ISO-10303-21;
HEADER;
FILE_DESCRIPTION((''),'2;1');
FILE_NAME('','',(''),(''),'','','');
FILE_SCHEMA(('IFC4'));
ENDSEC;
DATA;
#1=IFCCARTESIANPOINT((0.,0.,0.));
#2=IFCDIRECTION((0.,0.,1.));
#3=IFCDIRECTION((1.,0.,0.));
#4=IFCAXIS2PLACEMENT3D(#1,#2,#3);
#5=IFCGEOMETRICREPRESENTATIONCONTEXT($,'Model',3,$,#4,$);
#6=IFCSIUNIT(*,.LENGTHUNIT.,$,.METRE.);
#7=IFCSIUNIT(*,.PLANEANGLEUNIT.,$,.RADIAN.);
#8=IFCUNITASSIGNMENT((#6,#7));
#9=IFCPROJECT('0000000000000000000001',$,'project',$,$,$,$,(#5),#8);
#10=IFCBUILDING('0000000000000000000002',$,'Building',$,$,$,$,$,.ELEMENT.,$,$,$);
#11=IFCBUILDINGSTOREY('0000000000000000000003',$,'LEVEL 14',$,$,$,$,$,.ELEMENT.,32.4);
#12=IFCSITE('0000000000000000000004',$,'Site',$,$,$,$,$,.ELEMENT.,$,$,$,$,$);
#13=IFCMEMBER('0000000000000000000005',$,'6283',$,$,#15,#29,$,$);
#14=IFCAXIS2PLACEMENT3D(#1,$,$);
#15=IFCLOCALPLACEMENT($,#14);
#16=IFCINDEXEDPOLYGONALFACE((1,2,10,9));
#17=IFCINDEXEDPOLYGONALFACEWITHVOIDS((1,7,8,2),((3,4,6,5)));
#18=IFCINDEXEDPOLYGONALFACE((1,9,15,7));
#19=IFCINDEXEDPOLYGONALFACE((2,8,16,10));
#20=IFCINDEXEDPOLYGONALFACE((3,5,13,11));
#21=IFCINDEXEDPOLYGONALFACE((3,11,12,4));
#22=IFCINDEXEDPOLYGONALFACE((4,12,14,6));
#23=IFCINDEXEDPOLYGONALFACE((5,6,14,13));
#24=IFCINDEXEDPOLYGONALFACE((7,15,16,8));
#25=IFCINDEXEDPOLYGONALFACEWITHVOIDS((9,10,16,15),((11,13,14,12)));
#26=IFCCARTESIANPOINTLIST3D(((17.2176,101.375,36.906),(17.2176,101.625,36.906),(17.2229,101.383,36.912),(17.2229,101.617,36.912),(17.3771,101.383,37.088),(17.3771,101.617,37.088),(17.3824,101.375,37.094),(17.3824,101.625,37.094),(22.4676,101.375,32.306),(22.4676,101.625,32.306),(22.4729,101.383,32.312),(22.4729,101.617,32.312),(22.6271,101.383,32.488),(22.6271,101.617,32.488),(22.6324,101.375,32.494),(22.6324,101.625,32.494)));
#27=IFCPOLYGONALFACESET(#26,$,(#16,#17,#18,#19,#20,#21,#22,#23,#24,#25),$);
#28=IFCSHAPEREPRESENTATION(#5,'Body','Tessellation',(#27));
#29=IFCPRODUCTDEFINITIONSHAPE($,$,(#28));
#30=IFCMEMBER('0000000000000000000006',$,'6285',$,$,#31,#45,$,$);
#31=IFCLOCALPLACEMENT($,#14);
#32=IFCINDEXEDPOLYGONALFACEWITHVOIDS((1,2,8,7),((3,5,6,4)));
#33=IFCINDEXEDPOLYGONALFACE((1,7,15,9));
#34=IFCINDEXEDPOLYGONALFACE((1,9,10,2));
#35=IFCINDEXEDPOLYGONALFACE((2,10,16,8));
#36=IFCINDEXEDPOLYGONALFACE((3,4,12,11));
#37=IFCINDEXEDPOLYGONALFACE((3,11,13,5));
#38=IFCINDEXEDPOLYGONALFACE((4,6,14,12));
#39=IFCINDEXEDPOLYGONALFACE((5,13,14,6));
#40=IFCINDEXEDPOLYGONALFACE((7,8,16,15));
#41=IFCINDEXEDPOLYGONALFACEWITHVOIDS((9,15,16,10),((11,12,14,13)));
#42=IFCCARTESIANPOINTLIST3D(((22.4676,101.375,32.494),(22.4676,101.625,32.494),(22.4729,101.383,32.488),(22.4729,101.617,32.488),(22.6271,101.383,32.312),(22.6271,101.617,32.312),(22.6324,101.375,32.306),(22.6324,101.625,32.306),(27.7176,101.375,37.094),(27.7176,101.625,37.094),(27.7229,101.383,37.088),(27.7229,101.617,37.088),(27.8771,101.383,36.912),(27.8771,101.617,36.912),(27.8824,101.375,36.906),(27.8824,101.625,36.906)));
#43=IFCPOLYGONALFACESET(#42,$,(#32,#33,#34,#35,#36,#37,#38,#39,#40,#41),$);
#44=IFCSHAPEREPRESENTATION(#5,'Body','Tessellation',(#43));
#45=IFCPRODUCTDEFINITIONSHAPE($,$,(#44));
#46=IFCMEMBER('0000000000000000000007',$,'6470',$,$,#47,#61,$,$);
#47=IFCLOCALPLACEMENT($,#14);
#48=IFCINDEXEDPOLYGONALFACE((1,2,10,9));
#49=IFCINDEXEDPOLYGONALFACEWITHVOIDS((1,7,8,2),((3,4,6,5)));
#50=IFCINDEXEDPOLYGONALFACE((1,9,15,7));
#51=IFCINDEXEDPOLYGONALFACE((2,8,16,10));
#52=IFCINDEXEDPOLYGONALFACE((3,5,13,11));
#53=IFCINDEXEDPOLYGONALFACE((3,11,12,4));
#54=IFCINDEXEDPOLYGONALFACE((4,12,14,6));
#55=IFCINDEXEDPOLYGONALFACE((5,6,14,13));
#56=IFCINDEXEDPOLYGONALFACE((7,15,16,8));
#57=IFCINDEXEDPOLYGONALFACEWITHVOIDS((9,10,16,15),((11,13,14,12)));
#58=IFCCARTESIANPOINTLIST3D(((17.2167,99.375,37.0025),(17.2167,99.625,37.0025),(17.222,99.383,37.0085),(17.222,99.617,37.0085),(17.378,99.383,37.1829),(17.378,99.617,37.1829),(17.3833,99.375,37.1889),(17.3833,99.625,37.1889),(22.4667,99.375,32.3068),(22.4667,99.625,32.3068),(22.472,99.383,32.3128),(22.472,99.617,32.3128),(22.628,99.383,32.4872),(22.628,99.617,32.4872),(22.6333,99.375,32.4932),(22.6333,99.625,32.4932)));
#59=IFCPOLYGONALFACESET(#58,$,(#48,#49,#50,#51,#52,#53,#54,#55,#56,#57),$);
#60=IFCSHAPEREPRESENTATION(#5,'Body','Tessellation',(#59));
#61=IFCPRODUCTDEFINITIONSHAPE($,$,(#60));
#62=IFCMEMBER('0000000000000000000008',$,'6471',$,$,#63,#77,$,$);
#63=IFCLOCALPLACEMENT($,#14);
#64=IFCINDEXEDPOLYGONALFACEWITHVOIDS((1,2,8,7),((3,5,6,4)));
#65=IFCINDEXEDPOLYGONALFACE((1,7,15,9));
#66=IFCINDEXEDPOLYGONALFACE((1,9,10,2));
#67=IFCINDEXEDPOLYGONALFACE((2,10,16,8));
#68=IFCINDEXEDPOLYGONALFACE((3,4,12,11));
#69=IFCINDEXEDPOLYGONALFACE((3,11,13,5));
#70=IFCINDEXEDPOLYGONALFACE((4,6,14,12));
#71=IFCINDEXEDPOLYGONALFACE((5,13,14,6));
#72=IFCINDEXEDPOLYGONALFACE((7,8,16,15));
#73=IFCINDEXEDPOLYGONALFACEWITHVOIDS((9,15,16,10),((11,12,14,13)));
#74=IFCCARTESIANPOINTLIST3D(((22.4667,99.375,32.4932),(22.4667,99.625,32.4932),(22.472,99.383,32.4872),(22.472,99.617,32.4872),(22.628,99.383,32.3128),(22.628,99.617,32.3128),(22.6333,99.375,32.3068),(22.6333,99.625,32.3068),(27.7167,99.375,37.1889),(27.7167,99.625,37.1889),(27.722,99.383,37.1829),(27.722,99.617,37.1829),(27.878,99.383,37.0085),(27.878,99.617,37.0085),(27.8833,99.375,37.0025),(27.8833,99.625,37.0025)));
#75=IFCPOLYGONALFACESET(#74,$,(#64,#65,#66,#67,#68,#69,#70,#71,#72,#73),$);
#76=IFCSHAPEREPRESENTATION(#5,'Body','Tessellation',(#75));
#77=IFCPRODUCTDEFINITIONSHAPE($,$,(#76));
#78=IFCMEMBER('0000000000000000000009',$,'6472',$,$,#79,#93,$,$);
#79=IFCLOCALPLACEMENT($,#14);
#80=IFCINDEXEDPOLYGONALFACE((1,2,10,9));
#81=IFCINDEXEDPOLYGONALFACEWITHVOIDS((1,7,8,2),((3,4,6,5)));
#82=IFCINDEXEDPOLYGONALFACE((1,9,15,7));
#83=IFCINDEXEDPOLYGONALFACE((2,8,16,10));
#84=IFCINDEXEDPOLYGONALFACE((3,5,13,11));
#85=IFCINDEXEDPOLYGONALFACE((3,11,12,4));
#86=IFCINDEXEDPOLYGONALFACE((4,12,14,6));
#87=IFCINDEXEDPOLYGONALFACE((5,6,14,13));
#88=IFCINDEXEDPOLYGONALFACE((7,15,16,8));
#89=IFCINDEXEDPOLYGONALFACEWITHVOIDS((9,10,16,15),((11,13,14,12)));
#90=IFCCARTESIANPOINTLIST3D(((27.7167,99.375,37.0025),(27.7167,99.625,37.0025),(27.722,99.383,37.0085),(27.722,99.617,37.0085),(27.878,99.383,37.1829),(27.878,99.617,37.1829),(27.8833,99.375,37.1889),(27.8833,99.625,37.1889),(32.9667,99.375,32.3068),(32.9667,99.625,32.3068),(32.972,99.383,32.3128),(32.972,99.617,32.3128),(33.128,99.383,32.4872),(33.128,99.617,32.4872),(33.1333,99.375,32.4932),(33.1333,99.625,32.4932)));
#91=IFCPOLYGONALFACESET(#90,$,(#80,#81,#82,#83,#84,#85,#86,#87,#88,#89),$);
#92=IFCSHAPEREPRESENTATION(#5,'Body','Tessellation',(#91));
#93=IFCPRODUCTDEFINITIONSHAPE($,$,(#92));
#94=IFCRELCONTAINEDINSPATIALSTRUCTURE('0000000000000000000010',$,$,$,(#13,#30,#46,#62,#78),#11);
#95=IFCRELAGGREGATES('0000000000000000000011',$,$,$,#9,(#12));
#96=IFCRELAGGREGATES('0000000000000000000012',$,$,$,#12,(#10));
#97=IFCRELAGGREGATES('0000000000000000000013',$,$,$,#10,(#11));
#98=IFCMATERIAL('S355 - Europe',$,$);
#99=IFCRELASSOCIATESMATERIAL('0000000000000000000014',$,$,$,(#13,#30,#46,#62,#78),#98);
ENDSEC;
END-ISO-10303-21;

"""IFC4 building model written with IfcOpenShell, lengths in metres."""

from ifc_helpers import new_model, si_unit, frame, origin_with_axes, origin_2d_with_axis, place, context, project, spatial, hollow_rectangle, extrude, material, material_profile, profile_set, profile_usage, element, save


model = new_model("IFC4")

# Units and contexts
model_context = context("Model", 3, world=origin_with_axes())
ifc_project = project(units=[si_unit("LENGTHUNIT", "METRE"), si_unit("PLANEANGLEUNIT", "RADIAN")], contexts=[model_context])

# Site, building, storey
site = spatial("IfcSite", under=ifc_project, Name="Site", CompositionType="ELEMENT")
building = spatial("IfcBuilding", under=site, Name="Building", CompositionType="ELEMENT")
storey = spatial("IfcBuildingStorey", under=building, Name="LEVEL 14", CompositionType="ELEMENT", Elevation=32.4)

# Shared definitions
ifc_material = material(Name="S355 - Europe")

# Members
ifc_material_profile_1 = material_profile(ifc_material, hollow_rectangle(XDim=0.25, YDim=0.25, WallThickness=0.008, at=origin_2d_with_axis()))
ifc_profile_set_1 = profile_set([ifc_material_profile_1])
ifc_profile_usage_1 = profile_usage(ifc_profile_set_1, cardinal=10)
member_1_placement = place(None, frame((17.3, 101.5, 37.0), z_axis=(0.752133, 0.0, -0.659012), x_axis=(0.0, 1.0, 0.0)))
element("IfcMember", 1, at=member_1_placement, inside=storey, material=ifc_profile_usage_1, Name="6283", context=model_context, shape_type="SweptSolid", body=[
    extrude(hollow_rectangle(XDim=0.25, YDim=0.25, WallThickness=0.008, at=origin_2d_with_axis()), origin_with_axes(), (0.0, 0.0, 1.0), 6.9802),
])
ifc_material_profile_2 = material_profile(ifc_material, hollow_rectangle(XDim=0.25, YDim=0.25, WallThickness=0.008, at=origin_2d_with_axis()))
ifc_profile_set_2 = profile_set([ifc_material_profile_2])
ifc_profile_usage_2 = profile_usage(ifc_profile_set_2, cardinal=10)
member_2_placement = place(None, frame((22.55, 101.5, 32.4), z_axis=(0.752133, 0.0, 0.659012), x_axis=(0.0, 1.0, 0.0)))
element("IfcMember", 2, at=member_2_placement, inside=storey, material=ifc_profile_usage_2, Name="6285", context=model_context, shape_type="SweptSolid", body=[
    extrude(hollow_rectangle(XDim=0.25, YDim=0.25, WallThickness=0.008, at=origin_2d_with_axis()), origin_with_axes(), (0.0, 0.0, 1.0), 6.9802),
])
ifc_material_profile_3 = material_profile(ifc_material, hollow_rectangle(XDim=0.25, YDim=0.25, WallThickness=0.008, at=origin_2d_with_axis()))
ifc_profile_set_3 = profile_set([ifc_material_profile_3])
ifc_profile_usage_3 = profile_usage(ifc_profile_set_3, cardinal=10)
member_3_placement = place(None, frame((17.3, 99.5, 37.0957), z_axis=(0.745359, 0.0, -0.666663), x_axis=(0.0, 1.0, 0.0)))
element("IfcMember", 3, at=member_3_placement, inside=storey, material=ifc_profile_usage_3, Name="6470", context=model_context, shape_type="SweptSolid", body=[
    extrude(hollow_rectangle(XDim=0.25, YDim=0.25, WallThickness=0.008, at=origin_2d_with_axis()), origin_with_axes(), (0.0, 0.0, 1.0), 7.0436),
])
ifc_material_profile_4 = material_profile(ifc_material, hollow_rectangle(XDim=0.25, YDim=0.25, WallThickness=0.008, at=origin_2d_with_axis()))
ifc_profile_set_4 = profile_set([ifc_material_profile_4])
ifc_profile_usage_4 = profile_usage(ifc_profile_set_4, cardinal=10)
member_4_placement = place(None, frame((22.55, 99.5, 32.4), z_axis=(0.745359, 0.0, 0.666663), x_axis=(0.0, 1.0, 0.0)))
element("IfcMember", 4, at=member_4_placement, inside=storey, material=ifc_profile_usage_4, Name="6471", context=model_context, shape_type="SweptSolid", body=[
    extrude(hollow_rectangle(XDim=0.25, YDim=0.25, WallThickness=0.008, at=origin_2d_with_axis()), origin_with_axes(), (0.0, 0.0, 1.0), 7.0436),
])
ifc_material_profile_5 = material_profile(ifc_material, hollow_rectangle(XDim=0.25, YDim=0.25, WallThickness=0.008, at=origin_2d_with_axis()))
ifc_profile_set_5 = profile_set([ifc_material_profile_5])
ifc_profile_usage_5 = profile_usage(ifc_profile_set_5, cardinal=10)
member_5_placement = place(None, frame((27.8, 99.5, 37.0957), z_axis=(0.745359, 0.0, -0.666663), x_axis=(0.0, 1.0, 0.0)))
element("IfcMember", 5, at=member_5_placement, inside=storey, material=ifc_profile_usage_5, Name="6472", context=model_context, shape_type="SweptSolid", body=[
    extrude(hollow_rectangle(XDim=0.25, YDim=0.25, WallThickness=0.008, at=origin_2d_with_axis()), origin_with_axes(), (0.0, 0.0, 1.0), 7.0436),
])

save(model, "model.ifc")
